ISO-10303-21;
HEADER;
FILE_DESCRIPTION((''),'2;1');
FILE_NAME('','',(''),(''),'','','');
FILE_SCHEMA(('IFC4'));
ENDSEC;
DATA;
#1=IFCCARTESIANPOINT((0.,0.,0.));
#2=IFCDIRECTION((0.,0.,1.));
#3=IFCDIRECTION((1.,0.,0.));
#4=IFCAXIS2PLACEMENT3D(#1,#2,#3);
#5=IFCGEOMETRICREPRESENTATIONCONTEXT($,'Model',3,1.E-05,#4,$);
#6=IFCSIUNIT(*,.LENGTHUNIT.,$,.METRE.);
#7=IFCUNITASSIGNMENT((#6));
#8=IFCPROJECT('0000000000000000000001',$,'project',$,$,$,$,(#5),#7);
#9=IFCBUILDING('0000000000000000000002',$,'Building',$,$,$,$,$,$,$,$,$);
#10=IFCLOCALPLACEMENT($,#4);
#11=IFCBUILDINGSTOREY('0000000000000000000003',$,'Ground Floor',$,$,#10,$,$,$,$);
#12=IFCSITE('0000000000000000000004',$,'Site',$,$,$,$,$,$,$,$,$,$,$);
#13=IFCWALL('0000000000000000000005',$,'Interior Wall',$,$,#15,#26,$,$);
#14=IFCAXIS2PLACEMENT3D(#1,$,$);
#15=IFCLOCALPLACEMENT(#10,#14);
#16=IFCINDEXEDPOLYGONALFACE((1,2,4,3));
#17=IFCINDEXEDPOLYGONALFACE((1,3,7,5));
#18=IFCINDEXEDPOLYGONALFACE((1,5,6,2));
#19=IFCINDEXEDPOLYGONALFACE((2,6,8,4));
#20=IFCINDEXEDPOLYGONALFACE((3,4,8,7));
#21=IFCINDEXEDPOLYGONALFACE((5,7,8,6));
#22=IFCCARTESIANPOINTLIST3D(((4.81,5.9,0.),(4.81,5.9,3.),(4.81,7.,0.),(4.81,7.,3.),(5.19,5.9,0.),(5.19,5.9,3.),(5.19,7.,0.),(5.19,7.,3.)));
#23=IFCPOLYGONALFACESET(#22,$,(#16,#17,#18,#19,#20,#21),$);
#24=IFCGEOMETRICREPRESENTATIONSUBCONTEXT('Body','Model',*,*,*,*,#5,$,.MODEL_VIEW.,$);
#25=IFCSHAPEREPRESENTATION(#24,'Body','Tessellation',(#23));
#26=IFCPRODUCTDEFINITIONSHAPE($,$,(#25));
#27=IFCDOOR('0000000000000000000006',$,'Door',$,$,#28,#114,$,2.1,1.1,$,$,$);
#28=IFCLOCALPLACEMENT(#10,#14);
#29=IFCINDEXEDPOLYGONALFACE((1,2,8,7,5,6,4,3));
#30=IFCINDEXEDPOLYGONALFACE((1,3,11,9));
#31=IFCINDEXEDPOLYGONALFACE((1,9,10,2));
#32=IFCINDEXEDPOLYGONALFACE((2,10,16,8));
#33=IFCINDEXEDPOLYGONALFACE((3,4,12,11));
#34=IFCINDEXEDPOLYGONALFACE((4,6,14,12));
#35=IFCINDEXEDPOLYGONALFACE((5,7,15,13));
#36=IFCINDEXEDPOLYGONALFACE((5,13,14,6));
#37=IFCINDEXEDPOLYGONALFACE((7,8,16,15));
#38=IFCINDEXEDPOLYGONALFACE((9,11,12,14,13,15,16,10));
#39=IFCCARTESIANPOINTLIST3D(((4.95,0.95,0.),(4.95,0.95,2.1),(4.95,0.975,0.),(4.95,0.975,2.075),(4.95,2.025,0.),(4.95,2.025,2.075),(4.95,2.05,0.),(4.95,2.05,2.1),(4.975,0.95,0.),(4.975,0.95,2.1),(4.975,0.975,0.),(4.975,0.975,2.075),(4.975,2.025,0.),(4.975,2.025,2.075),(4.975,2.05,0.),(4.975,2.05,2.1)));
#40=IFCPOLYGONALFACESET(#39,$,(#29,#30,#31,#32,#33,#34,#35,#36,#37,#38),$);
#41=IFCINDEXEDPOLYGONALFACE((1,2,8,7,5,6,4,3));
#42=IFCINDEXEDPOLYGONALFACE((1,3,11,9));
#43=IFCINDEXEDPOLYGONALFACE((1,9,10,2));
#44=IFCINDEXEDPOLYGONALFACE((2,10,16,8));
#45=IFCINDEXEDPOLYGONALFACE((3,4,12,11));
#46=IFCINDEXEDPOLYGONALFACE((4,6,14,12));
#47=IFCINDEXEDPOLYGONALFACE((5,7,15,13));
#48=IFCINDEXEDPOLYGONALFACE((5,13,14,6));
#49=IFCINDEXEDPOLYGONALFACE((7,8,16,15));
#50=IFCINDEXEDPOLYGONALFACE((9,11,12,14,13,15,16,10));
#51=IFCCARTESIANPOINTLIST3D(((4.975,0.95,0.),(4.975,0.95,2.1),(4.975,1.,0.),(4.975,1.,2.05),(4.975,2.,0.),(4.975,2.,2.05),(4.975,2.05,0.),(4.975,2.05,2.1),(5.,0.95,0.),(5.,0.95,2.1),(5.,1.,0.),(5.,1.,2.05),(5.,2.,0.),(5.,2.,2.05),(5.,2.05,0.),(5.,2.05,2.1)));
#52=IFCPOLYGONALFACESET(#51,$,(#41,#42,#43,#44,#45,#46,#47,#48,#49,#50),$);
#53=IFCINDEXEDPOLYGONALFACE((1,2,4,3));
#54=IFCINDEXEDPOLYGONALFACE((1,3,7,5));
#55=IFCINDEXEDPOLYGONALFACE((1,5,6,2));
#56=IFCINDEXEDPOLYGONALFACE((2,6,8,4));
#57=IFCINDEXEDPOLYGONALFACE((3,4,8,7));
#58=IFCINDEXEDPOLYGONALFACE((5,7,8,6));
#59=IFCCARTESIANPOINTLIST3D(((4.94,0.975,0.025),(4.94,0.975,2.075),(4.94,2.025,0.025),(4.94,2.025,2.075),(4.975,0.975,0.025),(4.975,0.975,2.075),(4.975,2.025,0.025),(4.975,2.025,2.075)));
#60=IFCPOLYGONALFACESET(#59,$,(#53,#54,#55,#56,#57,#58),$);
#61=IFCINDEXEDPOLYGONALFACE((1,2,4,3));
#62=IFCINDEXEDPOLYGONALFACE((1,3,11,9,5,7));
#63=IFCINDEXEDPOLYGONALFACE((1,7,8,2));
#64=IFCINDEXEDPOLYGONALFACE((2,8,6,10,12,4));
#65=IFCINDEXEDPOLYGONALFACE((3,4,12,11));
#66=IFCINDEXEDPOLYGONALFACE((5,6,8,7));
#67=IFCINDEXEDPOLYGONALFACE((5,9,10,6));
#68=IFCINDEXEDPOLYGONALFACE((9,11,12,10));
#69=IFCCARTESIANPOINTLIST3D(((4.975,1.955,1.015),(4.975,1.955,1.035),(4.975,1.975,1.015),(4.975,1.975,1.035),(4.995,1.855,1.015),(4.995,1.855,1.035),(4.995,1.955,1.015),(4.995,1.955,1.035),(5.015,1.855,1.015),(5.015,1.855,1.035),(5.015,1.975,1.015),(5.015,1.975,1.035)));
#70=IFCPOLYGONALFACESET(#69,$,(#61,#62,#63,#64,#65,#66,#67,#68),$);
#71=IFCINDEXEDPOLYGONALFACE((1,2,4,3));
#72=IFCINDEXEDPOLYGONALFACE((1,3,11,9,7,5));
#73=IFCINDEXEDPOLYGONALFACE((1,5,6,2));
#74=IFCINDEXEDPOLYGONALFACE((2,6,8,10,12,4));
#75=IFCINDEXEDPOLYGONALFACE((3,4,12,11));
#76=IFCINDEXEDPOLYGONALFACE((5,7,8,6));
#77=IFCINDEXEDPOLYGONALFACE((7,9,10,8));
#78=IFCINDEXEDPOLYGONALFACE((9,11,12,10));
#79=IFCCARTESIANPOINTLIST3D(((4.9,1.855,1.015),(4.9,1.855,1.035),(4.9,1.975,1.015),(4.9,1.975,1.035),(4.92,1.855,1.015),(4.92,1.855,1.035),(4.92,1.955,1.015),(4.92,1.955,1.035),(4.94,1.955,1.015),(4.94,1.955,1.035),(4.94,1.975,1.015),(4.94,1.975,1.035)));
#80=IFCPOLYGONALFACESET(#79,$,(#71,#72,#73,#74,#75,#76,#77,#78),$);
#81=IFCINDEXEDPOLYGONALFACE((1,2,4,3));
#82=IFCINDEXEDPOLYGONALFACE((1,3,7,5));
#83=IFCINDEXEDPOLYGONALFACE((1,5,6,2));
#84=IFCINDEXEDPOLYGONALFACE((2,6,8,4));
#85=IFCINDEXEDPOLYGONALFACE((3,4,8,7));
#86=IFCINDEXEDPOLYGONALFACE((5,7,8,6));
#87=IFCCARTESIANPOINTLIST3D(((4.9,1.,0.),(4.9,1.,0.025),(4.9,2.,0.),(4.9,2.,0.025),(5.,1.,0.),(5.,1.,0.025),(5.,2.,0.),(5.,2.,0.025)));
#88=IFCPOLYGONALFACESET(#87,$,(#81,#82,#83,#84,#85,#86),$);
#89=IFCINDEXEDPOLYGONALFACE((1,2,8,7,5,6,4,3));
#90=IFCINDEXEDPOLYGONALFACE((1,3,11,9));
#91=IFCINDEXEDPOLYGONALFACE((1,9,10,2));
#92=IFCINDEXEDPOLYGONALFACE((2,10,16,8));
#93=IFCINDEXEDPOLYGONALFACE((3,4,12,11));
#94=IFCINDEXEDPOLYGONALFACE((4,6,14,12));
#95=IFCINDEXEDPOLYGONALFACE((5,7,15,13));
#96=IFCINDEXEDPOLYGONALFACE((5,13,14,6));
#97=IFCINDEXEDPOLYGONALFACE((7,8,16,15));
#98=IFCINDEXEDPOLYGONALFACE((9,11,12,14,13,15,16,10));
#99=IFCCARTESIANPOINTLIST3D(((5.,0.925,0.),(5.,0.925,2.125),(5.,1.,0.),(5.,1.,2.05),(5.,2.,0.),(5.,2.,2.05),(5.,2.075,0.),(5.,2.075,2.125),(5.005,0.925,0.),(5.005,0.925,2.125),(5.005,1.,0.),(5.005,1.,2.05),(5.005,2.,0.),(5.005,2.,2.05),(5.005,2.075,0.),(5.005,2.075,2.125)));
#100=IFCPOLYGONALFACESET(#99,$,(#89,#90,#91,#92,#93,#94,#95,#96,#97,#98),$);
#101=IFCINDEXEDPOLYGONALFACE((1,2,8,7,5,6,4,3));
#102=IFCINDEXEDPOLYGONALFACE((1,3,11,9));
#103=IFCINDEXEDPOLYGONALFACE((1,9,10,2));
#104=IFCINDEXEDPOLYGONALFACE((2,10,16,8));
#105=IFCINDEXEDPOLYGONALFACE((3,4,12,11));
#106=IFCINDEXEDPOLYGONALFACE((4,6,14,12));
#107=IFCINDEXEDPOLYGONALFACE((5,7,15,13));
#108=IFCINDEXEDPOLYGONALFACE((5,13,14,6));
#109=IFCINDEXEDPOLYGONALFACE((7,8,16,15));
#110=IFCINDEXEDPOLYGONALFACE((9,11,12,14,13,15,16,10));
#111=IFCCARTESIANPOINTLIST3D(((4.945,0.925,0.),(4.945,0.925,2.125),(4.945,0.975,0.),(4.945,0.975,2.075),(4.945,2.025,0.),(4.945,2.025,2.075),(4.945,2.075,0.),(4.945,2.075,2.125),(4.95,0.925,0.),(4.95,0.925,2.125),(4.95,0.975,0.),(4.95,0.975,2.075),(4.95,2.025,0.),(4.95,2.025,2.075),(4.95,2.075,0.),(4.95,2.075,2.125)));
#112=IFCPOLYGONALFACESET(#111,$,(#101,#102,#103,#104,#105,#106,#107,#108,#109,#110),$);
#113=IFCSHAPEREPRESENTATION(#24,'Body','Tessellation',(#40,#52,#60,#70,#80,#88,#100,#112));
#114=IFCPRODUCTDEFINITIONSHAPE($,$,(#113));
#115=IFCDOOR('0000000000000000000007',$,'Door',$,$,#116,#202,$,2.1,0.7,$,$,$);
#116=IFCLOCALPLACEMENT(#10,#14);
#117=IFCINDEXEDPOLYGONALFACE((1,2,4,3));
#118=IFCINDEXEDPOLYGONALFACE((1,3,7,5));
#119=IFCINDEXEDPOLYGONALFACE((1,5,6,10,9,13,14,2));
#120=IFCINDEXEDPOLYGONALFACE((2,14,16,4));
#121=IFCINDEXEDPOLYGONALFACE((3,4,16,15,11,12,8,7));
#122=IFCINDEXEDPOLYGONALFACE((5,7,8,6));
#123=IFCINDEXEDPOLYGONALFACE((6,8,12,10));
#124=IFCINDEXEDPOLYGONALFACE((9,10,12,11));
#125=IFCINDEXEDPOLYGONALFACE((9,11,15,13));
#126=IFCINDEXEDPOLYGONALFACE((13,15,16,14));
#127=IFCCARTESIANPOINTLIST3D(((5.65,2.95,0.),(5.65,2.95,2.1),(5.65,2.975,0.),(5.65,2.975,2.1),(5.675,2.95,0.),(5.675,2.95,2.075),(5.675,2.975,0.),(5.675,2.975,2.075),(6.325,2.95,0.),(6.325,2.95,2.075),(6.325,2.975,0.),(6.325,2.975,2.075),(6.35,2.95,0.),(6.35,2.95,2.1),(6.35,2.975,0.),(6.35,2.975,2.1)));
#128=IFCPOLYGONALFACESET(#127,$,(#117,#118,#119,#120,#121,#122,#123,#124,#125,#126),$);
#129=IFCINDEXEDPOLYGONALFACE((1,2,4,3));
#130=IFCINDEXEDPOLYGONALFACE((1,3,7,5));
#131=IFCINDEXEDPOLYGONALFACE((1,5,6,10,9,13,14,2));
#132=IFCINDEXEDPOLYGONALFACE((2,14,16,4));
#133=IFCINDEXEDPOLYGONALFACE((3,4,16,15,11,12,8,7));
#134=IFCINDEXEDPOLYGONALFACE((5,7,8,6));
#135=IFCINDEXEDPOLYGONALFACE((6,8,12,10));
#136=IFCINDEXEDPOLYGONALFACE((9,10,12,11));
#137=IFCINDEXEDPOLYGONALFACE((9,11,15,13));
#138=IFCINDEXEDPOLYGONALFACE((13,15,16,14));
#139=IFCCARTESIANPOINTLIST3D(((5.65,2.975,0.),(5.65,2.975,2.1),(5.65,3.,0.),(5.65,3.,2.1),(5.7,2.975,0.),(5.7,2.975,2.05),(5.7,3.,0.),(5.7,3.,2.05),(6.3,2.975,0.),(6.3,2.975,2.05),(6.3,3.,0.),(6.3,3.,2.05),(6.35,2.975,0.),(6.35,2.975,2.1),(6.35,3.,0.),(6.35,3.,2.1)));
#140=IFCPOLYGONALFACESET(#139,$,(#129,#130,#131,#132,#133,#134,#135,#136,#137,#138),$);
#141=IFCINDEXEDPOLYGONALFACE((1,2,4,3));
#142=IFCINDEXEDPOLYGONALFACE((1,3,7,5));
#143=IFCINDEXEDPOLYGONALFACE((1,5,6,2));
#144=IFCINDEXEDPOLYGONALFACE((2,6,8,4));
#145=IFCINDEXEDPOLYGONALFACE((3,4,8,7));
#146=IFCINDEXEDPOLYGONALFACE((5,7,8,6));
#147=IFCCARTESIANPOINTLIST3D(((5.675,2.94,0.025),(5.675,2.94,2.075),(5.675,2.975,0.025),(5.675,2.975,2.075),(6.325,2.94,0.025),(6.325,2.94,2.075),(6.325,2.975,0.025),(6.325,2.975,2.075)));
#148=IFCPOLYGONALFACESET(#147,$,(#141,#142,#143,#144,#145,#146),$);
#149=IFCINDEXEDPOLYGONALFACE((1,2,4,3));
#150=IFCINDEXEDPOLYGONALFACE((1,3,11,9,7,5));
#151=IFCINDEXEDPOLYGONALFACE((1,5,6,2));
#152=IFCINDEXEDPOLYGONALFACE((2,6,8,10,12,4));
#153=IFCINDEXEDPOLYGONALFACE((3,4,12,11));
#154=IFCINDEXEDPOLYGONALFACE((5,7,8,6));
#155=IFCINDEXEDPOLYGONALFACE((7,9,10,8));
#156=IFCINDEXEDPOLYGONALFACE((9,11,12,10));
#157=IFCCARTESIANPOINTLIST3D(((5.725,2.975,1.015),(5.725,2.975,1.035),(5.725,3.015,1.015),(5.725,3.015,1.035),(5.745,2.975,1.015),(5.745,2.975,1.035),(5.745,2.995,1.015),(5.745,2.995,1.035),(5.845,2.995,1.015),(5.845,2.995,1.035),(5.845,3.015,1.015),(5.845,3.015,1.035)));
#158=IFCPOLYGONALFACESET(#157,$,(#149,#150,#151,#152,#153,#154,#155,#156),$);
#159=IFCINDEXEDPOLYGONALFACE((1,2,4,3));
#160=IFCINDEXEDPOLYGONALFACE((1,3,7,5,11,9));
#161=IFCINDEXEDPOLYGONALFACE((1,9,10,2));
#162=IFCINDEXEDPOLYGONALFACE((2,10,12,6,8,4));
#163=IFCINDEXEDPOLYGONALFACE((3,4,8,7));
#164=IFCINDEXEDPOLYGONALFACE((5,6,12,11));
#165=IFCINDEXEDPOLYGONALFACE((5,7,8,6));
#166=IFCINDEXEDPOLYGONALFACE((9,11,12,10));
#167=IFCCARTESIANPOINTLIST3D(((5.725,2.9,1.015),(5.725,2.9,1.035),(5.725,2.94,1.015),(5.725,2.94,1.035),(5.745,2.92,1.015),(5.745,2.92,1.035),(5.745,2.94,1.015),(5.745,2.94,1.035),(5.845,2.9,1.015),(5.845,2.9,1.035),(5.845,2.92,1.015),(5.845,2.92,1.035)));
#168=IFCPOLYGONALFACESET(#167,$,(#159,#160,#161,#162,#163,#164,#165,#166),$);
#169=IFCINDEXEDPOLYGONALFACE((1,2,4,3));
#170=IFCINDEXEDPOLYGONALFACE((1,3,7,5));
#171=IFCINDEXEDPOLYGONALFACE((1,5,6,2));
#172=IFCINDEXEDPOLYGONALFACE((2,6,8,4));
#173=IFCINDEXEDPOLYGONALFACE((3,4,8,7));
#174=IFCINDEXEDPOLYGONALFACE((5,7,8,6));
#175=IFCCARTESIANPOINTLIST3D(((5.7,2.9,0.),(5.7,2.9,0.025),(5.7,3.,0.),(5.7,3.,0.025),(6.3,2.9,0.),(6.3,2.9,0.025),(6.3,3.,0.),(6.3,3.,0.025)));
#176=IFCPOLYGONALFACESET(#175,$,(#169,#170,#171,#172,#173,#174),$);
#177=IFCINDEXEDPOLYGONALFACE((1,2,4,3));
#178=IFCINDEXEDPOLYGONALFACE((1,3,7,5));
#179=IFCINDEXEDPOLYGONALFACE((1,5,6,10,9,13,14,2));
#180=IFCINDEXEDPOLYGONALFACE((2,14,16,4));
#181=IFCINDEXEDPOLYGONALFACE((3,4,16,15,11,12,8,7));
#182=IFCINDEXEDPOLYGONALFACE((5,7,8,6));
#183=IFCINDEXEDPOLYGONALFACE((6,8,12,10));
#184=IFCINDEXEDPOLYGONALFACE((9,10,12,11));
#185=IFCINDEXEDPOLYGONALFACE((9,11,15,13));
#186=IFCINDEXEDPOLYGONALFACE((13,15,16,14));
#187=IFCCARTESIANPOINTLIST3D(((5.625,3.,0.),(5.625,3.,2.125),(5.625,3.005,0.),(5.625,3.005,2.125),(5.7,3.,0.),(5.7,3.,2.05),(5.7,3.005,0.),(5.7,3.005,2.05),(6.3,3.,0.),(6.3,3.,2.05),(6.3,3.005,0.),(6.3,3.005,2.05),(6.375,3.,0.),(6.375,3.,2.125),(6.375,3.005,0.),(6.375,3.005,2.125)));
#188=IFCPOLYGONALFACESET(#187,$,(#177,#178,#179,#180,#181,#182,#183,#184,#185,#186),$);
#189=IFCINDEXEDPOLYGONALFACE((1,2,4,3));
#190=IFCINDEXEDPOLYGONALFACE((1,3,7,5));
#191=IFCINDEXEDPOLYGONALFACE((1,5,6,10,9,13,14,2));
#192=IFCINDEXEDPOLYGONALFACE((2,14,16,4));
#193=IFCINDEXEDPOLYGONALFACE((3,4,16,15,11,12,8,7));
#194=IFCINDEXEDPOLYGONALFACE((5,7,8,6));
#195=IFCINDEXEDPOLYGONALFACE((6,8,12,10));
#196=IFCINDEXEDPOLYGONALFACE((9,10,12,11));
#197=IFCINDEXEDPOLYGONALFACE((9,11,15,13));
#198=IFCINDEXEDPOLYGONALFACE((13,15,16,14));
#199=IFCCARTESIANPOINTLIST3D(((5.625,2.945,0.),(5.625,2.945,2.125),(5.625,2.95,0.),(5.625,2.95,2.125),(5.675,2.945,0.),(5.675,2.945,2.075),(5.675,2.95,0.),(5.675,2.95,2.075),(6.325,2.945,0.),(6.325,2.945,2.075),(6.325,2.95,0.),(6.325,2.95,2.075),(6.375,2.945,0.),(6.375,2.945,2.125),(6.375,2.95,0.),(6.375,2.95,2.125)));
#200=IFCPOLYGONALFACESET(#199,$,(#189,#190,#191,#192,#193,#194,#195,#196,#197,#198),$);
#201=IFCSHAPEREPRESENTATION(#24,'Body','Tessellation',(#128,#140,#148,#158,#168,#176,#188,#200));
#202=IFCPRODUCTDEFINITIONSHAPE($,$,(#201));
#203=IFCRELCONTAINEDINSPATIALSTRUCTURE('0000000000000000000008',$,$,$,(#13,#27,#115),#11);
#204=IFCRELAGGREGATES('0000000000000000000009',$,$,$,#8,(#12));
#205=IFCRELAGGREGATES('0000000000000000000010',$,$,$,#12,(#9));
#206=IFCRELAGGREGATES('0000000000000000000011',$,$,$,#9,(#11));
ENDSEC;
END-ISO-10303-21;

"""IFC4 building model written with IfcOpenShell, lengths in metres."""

from ifc_helpers import new_model, si_unit, frame, origin_with_axes, place, context, subcontext, project, spatial, line, indexed_curve, outline, extrude, element, save


model = new_model("IFC4")

# Units and contexts
model_context = context("Model", 3, precision=1e-05, world=origin_with_axes())
body_context = subcontext(model_context, "Body", "Model", "MODEL_VIEW")
ifc_project = project(units=[si_unit("LENGTHUNIT", "METRE")], contexts=[model_context])

# Site, building, storey
site = spatial("IfcSite", under=ifc_project, Name="Site")
building = spatial("IfcBuilding", under=site, Name="Building")
storey_placement = place(None, origin_with_axes())
storey = spatial("IfcBuildingStorey", under=building, at=storey_placement, Name="Ground Floor")

# Wall
for number, where, z_axis, x_axis, name in (
    (1, (5.0, 5.9, 0.0), (0.0, 0.0, 1.0), (0.0, 1.0, 0.0), "Interior Wall"),
):
    element("IfcWall", number, at=place(storey_placement, frame(where, z_axis=z_axis, x_axis=x_axis)), inside=storey, Name=name, context=body_context, shape_type="SweptSolid", body=[
        extrude(outline(indexed_curve([(0.0, 0.0), (0.0, 0.38), (1.1, 0.38), (1.1, 0.0), (0.0, 0.0)], self_intersect=False)), frame((0.0, -0.19, 0.0), z_axis=(0.0, 0.0, 1.0), x_axis=(1.0, 0.0, 0.0)), (0.0, 0.0, 1.0), 3.0),
    ])

# Doors
door_1_placement = place(storey_placement, frame((5.0, 0.95, 0.0), z_axis=(0.0, 0.0, 1.0), x_axis=(0.0, 1.0, 0.0)))
element("IfcDoor", 2, at=door_1_placement, inside=storey, Name="Door", OverallHeight=2.1, OverallWidth=1.1, context=body_context, shape_type="SweptSolid", body=[
    extrude(outline(indexed_curve([(0.0, 0.0), (0.0, 2.1), (1.1, 2.1), (1.1, 0.0), (1.075, 0.0), (1.075, 2.075), (0.025, 2.075), (0.025, 0.0)], segments=[line(1, 2, 3, 4, 5, 6, 7, 8, 1)])), frame((0.0, 0.025, 0.0), z_axis=(0.0, -1.0, 0.0), x_axis=(1.0, 0.0, 0.0)), (0.0, 0.0, -1.0), 0.025),
    extrude(outline(indexed_curve([(0.0, 0.0), (0.0, 2.1), (1.1, 2.1), (1.1, 0.0), (1.05, 0.0), (1.05, 2.05), (0.05, 2.05), (0.05, 0.0)], segments=[line(1, 2, 3, 4, 5, 6, 7, 8, 1)])), frame((0.0, 0.0, 0.0), z_axis=(0.0, -1.0, 0.0), x_axis=(1.0, 0.0, 0.0)), (0.0, 0.0, -1.0), 0.025),
    extrude(outline(indexed_curve([(0.0, 0.0), (1.05, 0.0), (1.05, 0.035), (0.0, 0.035)], segments=[line(1, 2, 3, 4, 1)])), frame((0.025, 0.025, 0.025), z_axis=(0.0, 0.0, 1.0), x_axis=(1.0, 0.0, 0.0)), (0.0, 0.0, 1.0), 2.05),
    extrude(outline(indexed_curve([(0.0, 0.0), (0.0, -0.04), (-0.12, -0.04), (-0.12, -0.02), (-0.02, -0.02), (-0.02, 0.0)], segments=[line(1, 2, 3, 4, 5, 6, 1)])), frame((1.025, 0.025, 1.015), z_axis=(0.0, 0.0, 1.0), x_axis=(1.0, 0.0, 0.0)), (0.0, 0.0, 1.0), 0.02),
    extrude(outline(indexed_curve([(0.0, 0.0), (0.0, 0.04), (-0.12, 0.04), (-0.12, 0.02), (-0.02, 0.02), (-0.02, 0.0)], segments=[line(1, 2, 3, 4, 5, 6, 1)])), frame((1.025, 0.06, 1.015), z_axis=(0.0, 0.0, 1.0), x_axis=(1.0, 0.0, 0.0)), (0.0, 0.0, 1.0), 0.02),
    extrude(outline(indexed_curve([(0.0, 0.0), (1.0, 0.0), (1.0, 0.1), (0.0, 0.1)], segments=[line(1, 2, 3, 4, 1)])), frame((0.05, 0.0, 0.0), z_axis=(0.0, 0.0, 1.0), x_axis=(1.0, 0.0, 0.0)), (0.0, 0.0, 1.0), 0.025),
    extrude(outline(indexed_curve([(0.0, 0.0), (0.0, 2.125), (1.15, 2.125), (1.15, 0.0), (1.075, 0.0), (1.075, 2.05), (0.075, 2.05), (0.075, 0.0)], segments=[line(1, 2, 3, 4, 5, 6, 7, 8, 1)])), frame((-0.025, -0.005, 0.0), z_axis=(0.0, -1.0, 0.0), x_axis=(1.0, 0.0, 0.0)), (0.0, 0.0, -1.0), 0.005),
    extrude(outline(indexed_curve([(0.0, 0.0), (0.0, 2.125), (1.15, 2.125), (1.15, 0.0), (1.1, 0.0), (1.1, 2.075), (0.05, 2.075), (0.05, 0.0)], segments=[line(1, 2, 3, 4, 5, 6, 7, 8, 1)])), frame((-0.025, 0.05, 0.0), z_axis=(0.0, -1.0, 0.0), x_axis=(1.0, 0.0, 0.0)), (0.0, 0.0, -1.0), 0.005),
])
door_2_placement = place(storey_placement, frame((6.35, 3.0, 0.0), z_axis=(0.0, 0.0, 1.0), x_axis=(-1.0, 0.0, 0.0)))
element("IfcDoor", 3, at=door_2_placement, inside=storey, Name="Door", OverallHeight=2.1, OverallWidth=0.7, context=body_context, shape_type="SweptSolid", body=[
    extrude(outline(indexed_curve([(0.0, 0.0), (0.0, 2.1), (0.7, 2.1), (0.7, 0.0), (0.675, 0.0), (0.675, 2.075), (0.025, 2.075), (0.025, 0.0)], segments=[line(1, 2, 3, 4, 5, 6, 7, 8, 1)])), frame((0.0, 0.025, 0.0), z_axis=(0.0, -1.0, 0.0), x_axis=(1.0, 0.0, 0.0)), (0.0, 0.0, -1.0), 0.025),
    extrude(outline(indexed_curve([(0.0, 0.0), (0.0, 2.1), (0.7, 2.1), (0.7, 0.0), (0.65, 0.0), (0.65, 2.05), (0.05, 2.05), (0.05, 0.0)], segments=[line(1, 2, 3, 4, 5, 6, 7, 8, 1)])), frame((0.0, 0.0, 0.0), z_axis=(0.0, -1.0, 0.0), x_axis=(1.0, 0.0, 0.0)), (0.0, 0.0, -1.0), 0.025),
    extrude(outline(indexed_curve([(0.0, 0.0), (0.65, 0.0), (0.65, 0.035), (0.0, 0.035)], segments=[line(1, 2, 3, 4, 1)])), frame((0.025, 0.025, 0.025), z_axis=(0.0, 0.0, 1.0), x_axis=(1.0, 0.0, 0.0)), (0.0, 0.0, 1.0), 2.05),
    extrude(outline(indexed_curve([(0.0, 0.0), (0.0, -0.04), (-0.12, -0.04), (-0.12, -0.02), (-0.02, -0.02), (-0.02, 0.0)], segments=[line(1, 2, 3, 4, 5, 6, 1)])), frame((0.625, 0.025, 1.015), z_axis=(0.0, 0.0, 1.0), x_axis=(1.0, 0.0, 0.0)), (0.0, 0.0, 1.0), 0.02),
    extrude(outline(indexed_curve([(0.0, 0.0), (0.0, 0.04), (-0.12, 0.04), (-0.12, 0.02), (-0.02, 0.02), (-0.02, 0.0)], segments=[line(1, 2, 3, 4, 5, 6, 1)])), frame((0.625, 0.06, 1.015), z_axis=(0.0, 0.0, 1.0), x_axis=(1.0, 0.0, 0.0)), (0.0, 0.0, 1.0), 0.02),
    extrude(outline(indexed_curve([(0.0, 0.0), (0.6, 0.0), (0.6, 0.1), (0.0, 0.1)], segments=[line(1, 2, 3, 4, 1)])), frame((0.05, 0.0, 0.0), z_axis=(0.0, 0.0, 1.0), x_axis=(1.0, 0.0, 0.0)), (0.0, 0.0, 1.0), 0.025),
    extrude(outline(indexed_curve([(0.0, 0.0), (0.0, 2.125), (0.75, 2.125), (0.75, 0.0), (0.675, 0.0), (0.675, 2.05), (0.075, 2.05), (0.075, 0.0)], segments=[line(1, 2, 3, 4, 5, 6, 7, 8, 1)])), frame((-0.025, -0.005, 0.0), z_axis=(0.0, -1.0, 0.0), x_axis=(1.0, 0.0, 0.0)), (0.0, 0.0, -1.0), 0.005),
    extrude(outline(indexed_curve([(0.0, 0.0), (0.0, 2.125), (0.75, 2.125), (0.75, 0.0), (0.7, 0.0), (0.7, 2.075), (0.05, 2.075), (0.05, 0.0)], segments=[line(1, 2, 3, 4, 5, 6, 7, 8, 1)])), frame((-0.025, 0.05, 0.0), z_axis=(0.0, -1.0, 0.0), x_axis=(1.0, 0.0, 0.0)), (0.0, 0.0, -1.0), 0.005),
])

save(model, "model.ifc")
